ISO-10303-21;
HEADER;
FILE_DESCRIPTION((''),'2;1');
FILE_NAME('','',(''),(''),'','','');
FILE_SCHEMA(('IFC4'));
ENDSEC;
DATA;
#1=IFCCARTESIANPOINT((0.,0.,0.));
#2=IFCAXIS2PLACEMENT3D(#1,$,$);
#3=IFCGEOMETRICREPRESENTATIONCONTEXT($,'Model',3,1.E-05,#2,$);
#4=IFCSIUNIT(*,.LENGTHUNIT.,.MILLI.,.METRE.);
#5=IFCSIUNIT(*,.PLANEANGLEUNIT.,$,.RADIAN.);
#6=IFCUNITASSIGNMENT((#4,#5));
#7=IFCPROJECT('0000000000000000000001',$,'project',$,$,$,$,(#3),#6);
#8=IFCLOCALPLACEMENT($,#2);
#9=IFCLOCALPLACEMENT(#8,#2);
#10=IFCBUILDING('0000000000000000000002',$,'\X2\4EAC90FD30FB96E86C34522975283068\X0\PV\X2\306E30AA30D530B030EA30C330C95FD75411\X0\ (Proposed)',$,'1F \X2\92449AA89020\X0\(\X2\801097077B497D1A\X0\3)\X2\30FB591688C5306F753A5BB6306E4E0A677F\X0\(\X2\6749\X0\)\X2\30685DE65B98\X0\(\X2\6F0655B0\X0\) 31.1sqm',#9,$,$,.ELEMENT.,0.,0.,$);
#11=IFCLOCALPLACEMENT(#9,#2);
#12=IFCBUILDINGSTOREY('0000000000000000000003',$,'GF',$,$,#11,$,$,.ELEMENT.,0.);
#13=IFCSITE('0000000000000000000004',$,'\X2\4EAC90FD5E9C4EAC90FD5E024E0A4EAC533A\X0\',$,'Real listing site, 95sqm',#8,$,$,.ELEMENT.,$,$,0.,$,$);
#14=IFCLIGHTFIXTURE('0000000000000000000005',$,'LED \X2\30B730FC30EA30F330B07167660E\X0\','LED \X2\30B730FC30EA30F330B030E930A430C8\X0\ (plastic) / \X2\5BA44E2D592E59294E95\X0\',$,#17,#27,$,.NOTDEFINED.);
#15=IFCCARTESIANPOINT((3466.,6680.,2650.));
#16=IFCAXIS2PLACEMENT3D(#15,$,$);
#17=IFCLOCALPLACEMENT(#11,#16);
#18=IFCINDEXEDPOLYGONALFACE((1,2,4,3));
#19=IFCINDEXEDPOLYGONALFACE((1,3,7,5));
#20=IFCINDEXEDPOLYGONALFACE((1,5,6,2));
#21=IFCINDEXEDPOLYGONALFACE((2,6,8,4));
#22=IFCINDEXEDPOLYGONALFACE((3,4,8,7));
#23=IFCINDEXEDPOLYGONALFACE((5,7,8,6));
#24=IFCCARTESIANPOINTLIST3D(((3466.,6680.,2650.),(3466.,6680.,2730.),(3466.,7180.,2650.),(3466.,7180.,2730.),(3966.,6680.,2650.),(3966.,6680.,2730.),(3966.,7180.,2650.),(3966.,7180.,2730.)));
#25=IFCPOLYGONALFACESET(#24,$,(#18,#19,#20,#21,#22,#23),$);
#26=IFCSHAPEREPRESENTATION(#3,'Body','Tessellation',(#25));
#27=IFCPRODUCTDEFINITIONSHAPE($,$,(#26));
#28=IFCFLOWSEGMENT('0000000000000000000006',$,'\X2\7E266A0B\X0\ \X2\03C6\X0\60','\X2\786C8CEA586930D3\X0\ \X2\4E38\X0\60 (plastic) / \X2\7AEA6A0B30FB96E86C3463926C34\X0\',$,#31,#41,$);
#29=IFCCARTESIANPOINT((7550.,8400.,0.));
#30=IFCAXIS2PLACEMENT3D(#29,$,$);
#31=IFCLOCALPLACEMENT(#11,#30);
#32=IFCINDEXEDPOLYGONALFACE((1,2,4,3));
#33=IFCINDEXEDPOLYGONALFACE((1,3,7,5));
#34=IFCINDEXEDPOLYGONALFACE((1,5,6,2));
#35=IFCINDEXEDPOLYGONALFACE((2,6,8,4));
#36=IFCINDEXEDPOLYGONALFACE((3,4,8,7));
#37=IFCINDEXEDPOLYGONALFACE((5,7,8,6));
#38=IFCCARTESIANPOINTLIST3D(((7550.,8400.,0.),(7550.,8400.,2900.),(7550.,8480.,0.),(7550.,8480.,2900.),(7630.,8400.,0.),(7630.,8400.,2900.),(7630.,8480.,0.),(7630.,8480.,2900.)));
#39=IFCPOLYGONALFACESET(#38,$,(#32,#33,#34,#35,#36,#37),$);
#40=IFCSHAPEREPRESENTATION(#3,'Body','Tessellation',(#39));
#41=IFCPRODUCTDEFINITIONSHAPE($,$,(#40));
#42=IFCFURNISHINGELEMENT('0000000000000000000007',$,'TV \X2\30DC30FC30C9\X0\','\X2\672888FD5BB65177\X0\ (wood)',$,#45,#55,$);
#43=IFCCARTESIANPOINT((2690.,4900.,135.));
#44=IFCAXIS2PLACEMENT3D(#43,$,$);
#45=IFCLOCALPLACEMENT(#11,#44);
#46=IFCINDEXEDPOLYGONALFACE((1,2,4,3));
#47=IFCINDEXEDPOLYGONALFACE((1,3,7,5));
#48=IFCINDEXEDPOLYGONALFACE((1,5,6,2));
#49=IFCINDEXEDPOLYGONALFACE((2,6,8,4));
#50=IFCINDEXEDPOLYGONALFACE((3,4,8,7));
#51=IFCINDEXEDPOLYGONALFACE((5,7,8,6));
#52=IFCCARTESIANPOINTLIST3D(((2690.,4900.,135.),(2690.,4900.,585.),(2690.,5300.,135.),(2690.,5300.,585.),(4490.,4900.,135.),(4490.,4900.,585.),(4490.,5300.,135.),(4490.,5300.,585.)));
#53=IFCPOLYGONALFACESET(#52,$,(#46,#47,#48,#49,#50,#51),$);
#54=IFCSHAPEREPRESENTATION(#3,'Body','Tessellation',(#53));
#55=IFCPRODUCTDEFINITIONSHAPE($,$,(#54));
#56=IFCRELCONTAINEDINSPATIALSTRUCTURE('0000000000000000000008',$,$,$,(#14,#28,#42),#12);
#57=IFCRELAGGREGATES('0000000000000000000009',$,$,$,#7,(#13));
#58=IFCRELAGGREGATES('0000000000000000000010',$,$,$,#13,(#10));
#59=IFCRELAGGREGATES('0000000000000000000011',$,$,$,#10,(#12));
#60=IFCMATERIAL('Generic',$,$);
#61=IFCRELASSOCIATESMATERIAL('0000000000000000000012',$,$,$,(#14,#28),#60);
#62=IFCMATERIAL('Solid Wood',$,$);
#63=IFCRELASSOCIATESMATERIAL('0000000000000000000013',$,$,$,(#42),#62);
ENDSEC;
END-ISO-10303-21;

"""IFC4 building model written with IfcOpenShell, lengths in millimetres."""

from ifc_helpers import new_model, si_unit, frame, frame_2d, origin, place, context, project, spatial, rectangle, extrude, material, element, save


model = new_model("IFC4")

# Units and contexts
model_context = context("Model", 3, precision=1e-05, world=origin())
ifc_project = project(units=[si_unit("LENGTHUNIT", "METRE", prefix="MILLI"), si_unit("PLANEANGLEUNIT", "RADIAN")], contexts=[model_context])

# Site, building, storey
site_placement = place(None, origin())
site = spatial("IfcSite", under=ifc_project, at=site_placement, Name="京都府京都市上京区", ObjectType="Real listing site, 95sqm", CompositionType="ELEMENT", RefElevation=0.0)
building_placement = place(site_placement, origin())
building = spatial("IfcBuilding", under=site, at=building_placement, Name="京都・雨水利用とPVのオフグリッド志向 (Proposed)", ObjectType="1F 鉄骨造(耐震等級3)・外装は町家の上板(杉)と左官(漆喰) 31.1sqm", CompositionType="ELEMENT", ElevationOfRefHeight=0.0, ElevationOfTerrain=0.0)
storey_placement = place(building_placement, origin())
storey = spatial("IfcBuildingStorey", under=building, at=storey_placement, Name="GF", CompositionType="ELEMENT", Elevation=0.0)

# Shared definitions
ifc_material_1 = material(Name="Solid Wood")

# Shared definitions
ifc_material_2 = material(Name="Generic")

# Light fixture
light_fixture_1_placement = place(storey_placement, frame((3466.0, 6680.0, 2650.0)))
element("IfcLightFixture", 1, at=light_fixture_1_placement, inside=storey, material=ifc_material_2, Name="LED シーリング照明", Description="LED シーリングライト (plastic) / 室中央天井", PredefinedType="NOTDEFINED", context=model_context, shape_type="SweptSolid", body=[
    extrude(rectangle(XDim=500.0, YDim=500.0, at=frame_2d((250.0, 250.0))), frame((3466.0, 6680.0, 2650.0)), (0.0, 0.0, 1.0), 80.0),
])

# Flow segment
flow_segment_placement = place(storey_placement, frame((7550.0, 8400.0, 0.0)))
element("IfcFlowSegment", 2, at=flow_segment_placement, inside=storey, material=ifc_material_2, Name="縦樋 φ60", Description="硬質塩ビ 丸60 (plastic) / 竪樋・雨水排水", context=model_context, shape_type="SweptSolid", body=[
    extrude(rectangle(XDim=80.0, YDim=80.0, at=frame_2d((40.0, 40.0))), frame((7550.0, 8400.0, 0.0)), (0.0, 0.0, 1.0), 2900.0),
])

# Furnishing element
furnishing_placement = place(storey_placement, frame((2690.0, 4900.0, 135.0)))
element("IfcFurnishingElement", 3, at=furnishing_placement, inside=storey, material=ifc_material_1, Name="TV ボード", Description="木製家具 (wood)", context=model_context, shape_type="SweptSolid", body=[
    extrude(rectangle(XDim=1800.0, YDim=400.0, at=frame_2d((900.0, 200.0))), frame((2690.0, 4900.0, 135.0)), (0.0, 0.0, 1.0), 450.0),
])

save(model, "model.ifc")
